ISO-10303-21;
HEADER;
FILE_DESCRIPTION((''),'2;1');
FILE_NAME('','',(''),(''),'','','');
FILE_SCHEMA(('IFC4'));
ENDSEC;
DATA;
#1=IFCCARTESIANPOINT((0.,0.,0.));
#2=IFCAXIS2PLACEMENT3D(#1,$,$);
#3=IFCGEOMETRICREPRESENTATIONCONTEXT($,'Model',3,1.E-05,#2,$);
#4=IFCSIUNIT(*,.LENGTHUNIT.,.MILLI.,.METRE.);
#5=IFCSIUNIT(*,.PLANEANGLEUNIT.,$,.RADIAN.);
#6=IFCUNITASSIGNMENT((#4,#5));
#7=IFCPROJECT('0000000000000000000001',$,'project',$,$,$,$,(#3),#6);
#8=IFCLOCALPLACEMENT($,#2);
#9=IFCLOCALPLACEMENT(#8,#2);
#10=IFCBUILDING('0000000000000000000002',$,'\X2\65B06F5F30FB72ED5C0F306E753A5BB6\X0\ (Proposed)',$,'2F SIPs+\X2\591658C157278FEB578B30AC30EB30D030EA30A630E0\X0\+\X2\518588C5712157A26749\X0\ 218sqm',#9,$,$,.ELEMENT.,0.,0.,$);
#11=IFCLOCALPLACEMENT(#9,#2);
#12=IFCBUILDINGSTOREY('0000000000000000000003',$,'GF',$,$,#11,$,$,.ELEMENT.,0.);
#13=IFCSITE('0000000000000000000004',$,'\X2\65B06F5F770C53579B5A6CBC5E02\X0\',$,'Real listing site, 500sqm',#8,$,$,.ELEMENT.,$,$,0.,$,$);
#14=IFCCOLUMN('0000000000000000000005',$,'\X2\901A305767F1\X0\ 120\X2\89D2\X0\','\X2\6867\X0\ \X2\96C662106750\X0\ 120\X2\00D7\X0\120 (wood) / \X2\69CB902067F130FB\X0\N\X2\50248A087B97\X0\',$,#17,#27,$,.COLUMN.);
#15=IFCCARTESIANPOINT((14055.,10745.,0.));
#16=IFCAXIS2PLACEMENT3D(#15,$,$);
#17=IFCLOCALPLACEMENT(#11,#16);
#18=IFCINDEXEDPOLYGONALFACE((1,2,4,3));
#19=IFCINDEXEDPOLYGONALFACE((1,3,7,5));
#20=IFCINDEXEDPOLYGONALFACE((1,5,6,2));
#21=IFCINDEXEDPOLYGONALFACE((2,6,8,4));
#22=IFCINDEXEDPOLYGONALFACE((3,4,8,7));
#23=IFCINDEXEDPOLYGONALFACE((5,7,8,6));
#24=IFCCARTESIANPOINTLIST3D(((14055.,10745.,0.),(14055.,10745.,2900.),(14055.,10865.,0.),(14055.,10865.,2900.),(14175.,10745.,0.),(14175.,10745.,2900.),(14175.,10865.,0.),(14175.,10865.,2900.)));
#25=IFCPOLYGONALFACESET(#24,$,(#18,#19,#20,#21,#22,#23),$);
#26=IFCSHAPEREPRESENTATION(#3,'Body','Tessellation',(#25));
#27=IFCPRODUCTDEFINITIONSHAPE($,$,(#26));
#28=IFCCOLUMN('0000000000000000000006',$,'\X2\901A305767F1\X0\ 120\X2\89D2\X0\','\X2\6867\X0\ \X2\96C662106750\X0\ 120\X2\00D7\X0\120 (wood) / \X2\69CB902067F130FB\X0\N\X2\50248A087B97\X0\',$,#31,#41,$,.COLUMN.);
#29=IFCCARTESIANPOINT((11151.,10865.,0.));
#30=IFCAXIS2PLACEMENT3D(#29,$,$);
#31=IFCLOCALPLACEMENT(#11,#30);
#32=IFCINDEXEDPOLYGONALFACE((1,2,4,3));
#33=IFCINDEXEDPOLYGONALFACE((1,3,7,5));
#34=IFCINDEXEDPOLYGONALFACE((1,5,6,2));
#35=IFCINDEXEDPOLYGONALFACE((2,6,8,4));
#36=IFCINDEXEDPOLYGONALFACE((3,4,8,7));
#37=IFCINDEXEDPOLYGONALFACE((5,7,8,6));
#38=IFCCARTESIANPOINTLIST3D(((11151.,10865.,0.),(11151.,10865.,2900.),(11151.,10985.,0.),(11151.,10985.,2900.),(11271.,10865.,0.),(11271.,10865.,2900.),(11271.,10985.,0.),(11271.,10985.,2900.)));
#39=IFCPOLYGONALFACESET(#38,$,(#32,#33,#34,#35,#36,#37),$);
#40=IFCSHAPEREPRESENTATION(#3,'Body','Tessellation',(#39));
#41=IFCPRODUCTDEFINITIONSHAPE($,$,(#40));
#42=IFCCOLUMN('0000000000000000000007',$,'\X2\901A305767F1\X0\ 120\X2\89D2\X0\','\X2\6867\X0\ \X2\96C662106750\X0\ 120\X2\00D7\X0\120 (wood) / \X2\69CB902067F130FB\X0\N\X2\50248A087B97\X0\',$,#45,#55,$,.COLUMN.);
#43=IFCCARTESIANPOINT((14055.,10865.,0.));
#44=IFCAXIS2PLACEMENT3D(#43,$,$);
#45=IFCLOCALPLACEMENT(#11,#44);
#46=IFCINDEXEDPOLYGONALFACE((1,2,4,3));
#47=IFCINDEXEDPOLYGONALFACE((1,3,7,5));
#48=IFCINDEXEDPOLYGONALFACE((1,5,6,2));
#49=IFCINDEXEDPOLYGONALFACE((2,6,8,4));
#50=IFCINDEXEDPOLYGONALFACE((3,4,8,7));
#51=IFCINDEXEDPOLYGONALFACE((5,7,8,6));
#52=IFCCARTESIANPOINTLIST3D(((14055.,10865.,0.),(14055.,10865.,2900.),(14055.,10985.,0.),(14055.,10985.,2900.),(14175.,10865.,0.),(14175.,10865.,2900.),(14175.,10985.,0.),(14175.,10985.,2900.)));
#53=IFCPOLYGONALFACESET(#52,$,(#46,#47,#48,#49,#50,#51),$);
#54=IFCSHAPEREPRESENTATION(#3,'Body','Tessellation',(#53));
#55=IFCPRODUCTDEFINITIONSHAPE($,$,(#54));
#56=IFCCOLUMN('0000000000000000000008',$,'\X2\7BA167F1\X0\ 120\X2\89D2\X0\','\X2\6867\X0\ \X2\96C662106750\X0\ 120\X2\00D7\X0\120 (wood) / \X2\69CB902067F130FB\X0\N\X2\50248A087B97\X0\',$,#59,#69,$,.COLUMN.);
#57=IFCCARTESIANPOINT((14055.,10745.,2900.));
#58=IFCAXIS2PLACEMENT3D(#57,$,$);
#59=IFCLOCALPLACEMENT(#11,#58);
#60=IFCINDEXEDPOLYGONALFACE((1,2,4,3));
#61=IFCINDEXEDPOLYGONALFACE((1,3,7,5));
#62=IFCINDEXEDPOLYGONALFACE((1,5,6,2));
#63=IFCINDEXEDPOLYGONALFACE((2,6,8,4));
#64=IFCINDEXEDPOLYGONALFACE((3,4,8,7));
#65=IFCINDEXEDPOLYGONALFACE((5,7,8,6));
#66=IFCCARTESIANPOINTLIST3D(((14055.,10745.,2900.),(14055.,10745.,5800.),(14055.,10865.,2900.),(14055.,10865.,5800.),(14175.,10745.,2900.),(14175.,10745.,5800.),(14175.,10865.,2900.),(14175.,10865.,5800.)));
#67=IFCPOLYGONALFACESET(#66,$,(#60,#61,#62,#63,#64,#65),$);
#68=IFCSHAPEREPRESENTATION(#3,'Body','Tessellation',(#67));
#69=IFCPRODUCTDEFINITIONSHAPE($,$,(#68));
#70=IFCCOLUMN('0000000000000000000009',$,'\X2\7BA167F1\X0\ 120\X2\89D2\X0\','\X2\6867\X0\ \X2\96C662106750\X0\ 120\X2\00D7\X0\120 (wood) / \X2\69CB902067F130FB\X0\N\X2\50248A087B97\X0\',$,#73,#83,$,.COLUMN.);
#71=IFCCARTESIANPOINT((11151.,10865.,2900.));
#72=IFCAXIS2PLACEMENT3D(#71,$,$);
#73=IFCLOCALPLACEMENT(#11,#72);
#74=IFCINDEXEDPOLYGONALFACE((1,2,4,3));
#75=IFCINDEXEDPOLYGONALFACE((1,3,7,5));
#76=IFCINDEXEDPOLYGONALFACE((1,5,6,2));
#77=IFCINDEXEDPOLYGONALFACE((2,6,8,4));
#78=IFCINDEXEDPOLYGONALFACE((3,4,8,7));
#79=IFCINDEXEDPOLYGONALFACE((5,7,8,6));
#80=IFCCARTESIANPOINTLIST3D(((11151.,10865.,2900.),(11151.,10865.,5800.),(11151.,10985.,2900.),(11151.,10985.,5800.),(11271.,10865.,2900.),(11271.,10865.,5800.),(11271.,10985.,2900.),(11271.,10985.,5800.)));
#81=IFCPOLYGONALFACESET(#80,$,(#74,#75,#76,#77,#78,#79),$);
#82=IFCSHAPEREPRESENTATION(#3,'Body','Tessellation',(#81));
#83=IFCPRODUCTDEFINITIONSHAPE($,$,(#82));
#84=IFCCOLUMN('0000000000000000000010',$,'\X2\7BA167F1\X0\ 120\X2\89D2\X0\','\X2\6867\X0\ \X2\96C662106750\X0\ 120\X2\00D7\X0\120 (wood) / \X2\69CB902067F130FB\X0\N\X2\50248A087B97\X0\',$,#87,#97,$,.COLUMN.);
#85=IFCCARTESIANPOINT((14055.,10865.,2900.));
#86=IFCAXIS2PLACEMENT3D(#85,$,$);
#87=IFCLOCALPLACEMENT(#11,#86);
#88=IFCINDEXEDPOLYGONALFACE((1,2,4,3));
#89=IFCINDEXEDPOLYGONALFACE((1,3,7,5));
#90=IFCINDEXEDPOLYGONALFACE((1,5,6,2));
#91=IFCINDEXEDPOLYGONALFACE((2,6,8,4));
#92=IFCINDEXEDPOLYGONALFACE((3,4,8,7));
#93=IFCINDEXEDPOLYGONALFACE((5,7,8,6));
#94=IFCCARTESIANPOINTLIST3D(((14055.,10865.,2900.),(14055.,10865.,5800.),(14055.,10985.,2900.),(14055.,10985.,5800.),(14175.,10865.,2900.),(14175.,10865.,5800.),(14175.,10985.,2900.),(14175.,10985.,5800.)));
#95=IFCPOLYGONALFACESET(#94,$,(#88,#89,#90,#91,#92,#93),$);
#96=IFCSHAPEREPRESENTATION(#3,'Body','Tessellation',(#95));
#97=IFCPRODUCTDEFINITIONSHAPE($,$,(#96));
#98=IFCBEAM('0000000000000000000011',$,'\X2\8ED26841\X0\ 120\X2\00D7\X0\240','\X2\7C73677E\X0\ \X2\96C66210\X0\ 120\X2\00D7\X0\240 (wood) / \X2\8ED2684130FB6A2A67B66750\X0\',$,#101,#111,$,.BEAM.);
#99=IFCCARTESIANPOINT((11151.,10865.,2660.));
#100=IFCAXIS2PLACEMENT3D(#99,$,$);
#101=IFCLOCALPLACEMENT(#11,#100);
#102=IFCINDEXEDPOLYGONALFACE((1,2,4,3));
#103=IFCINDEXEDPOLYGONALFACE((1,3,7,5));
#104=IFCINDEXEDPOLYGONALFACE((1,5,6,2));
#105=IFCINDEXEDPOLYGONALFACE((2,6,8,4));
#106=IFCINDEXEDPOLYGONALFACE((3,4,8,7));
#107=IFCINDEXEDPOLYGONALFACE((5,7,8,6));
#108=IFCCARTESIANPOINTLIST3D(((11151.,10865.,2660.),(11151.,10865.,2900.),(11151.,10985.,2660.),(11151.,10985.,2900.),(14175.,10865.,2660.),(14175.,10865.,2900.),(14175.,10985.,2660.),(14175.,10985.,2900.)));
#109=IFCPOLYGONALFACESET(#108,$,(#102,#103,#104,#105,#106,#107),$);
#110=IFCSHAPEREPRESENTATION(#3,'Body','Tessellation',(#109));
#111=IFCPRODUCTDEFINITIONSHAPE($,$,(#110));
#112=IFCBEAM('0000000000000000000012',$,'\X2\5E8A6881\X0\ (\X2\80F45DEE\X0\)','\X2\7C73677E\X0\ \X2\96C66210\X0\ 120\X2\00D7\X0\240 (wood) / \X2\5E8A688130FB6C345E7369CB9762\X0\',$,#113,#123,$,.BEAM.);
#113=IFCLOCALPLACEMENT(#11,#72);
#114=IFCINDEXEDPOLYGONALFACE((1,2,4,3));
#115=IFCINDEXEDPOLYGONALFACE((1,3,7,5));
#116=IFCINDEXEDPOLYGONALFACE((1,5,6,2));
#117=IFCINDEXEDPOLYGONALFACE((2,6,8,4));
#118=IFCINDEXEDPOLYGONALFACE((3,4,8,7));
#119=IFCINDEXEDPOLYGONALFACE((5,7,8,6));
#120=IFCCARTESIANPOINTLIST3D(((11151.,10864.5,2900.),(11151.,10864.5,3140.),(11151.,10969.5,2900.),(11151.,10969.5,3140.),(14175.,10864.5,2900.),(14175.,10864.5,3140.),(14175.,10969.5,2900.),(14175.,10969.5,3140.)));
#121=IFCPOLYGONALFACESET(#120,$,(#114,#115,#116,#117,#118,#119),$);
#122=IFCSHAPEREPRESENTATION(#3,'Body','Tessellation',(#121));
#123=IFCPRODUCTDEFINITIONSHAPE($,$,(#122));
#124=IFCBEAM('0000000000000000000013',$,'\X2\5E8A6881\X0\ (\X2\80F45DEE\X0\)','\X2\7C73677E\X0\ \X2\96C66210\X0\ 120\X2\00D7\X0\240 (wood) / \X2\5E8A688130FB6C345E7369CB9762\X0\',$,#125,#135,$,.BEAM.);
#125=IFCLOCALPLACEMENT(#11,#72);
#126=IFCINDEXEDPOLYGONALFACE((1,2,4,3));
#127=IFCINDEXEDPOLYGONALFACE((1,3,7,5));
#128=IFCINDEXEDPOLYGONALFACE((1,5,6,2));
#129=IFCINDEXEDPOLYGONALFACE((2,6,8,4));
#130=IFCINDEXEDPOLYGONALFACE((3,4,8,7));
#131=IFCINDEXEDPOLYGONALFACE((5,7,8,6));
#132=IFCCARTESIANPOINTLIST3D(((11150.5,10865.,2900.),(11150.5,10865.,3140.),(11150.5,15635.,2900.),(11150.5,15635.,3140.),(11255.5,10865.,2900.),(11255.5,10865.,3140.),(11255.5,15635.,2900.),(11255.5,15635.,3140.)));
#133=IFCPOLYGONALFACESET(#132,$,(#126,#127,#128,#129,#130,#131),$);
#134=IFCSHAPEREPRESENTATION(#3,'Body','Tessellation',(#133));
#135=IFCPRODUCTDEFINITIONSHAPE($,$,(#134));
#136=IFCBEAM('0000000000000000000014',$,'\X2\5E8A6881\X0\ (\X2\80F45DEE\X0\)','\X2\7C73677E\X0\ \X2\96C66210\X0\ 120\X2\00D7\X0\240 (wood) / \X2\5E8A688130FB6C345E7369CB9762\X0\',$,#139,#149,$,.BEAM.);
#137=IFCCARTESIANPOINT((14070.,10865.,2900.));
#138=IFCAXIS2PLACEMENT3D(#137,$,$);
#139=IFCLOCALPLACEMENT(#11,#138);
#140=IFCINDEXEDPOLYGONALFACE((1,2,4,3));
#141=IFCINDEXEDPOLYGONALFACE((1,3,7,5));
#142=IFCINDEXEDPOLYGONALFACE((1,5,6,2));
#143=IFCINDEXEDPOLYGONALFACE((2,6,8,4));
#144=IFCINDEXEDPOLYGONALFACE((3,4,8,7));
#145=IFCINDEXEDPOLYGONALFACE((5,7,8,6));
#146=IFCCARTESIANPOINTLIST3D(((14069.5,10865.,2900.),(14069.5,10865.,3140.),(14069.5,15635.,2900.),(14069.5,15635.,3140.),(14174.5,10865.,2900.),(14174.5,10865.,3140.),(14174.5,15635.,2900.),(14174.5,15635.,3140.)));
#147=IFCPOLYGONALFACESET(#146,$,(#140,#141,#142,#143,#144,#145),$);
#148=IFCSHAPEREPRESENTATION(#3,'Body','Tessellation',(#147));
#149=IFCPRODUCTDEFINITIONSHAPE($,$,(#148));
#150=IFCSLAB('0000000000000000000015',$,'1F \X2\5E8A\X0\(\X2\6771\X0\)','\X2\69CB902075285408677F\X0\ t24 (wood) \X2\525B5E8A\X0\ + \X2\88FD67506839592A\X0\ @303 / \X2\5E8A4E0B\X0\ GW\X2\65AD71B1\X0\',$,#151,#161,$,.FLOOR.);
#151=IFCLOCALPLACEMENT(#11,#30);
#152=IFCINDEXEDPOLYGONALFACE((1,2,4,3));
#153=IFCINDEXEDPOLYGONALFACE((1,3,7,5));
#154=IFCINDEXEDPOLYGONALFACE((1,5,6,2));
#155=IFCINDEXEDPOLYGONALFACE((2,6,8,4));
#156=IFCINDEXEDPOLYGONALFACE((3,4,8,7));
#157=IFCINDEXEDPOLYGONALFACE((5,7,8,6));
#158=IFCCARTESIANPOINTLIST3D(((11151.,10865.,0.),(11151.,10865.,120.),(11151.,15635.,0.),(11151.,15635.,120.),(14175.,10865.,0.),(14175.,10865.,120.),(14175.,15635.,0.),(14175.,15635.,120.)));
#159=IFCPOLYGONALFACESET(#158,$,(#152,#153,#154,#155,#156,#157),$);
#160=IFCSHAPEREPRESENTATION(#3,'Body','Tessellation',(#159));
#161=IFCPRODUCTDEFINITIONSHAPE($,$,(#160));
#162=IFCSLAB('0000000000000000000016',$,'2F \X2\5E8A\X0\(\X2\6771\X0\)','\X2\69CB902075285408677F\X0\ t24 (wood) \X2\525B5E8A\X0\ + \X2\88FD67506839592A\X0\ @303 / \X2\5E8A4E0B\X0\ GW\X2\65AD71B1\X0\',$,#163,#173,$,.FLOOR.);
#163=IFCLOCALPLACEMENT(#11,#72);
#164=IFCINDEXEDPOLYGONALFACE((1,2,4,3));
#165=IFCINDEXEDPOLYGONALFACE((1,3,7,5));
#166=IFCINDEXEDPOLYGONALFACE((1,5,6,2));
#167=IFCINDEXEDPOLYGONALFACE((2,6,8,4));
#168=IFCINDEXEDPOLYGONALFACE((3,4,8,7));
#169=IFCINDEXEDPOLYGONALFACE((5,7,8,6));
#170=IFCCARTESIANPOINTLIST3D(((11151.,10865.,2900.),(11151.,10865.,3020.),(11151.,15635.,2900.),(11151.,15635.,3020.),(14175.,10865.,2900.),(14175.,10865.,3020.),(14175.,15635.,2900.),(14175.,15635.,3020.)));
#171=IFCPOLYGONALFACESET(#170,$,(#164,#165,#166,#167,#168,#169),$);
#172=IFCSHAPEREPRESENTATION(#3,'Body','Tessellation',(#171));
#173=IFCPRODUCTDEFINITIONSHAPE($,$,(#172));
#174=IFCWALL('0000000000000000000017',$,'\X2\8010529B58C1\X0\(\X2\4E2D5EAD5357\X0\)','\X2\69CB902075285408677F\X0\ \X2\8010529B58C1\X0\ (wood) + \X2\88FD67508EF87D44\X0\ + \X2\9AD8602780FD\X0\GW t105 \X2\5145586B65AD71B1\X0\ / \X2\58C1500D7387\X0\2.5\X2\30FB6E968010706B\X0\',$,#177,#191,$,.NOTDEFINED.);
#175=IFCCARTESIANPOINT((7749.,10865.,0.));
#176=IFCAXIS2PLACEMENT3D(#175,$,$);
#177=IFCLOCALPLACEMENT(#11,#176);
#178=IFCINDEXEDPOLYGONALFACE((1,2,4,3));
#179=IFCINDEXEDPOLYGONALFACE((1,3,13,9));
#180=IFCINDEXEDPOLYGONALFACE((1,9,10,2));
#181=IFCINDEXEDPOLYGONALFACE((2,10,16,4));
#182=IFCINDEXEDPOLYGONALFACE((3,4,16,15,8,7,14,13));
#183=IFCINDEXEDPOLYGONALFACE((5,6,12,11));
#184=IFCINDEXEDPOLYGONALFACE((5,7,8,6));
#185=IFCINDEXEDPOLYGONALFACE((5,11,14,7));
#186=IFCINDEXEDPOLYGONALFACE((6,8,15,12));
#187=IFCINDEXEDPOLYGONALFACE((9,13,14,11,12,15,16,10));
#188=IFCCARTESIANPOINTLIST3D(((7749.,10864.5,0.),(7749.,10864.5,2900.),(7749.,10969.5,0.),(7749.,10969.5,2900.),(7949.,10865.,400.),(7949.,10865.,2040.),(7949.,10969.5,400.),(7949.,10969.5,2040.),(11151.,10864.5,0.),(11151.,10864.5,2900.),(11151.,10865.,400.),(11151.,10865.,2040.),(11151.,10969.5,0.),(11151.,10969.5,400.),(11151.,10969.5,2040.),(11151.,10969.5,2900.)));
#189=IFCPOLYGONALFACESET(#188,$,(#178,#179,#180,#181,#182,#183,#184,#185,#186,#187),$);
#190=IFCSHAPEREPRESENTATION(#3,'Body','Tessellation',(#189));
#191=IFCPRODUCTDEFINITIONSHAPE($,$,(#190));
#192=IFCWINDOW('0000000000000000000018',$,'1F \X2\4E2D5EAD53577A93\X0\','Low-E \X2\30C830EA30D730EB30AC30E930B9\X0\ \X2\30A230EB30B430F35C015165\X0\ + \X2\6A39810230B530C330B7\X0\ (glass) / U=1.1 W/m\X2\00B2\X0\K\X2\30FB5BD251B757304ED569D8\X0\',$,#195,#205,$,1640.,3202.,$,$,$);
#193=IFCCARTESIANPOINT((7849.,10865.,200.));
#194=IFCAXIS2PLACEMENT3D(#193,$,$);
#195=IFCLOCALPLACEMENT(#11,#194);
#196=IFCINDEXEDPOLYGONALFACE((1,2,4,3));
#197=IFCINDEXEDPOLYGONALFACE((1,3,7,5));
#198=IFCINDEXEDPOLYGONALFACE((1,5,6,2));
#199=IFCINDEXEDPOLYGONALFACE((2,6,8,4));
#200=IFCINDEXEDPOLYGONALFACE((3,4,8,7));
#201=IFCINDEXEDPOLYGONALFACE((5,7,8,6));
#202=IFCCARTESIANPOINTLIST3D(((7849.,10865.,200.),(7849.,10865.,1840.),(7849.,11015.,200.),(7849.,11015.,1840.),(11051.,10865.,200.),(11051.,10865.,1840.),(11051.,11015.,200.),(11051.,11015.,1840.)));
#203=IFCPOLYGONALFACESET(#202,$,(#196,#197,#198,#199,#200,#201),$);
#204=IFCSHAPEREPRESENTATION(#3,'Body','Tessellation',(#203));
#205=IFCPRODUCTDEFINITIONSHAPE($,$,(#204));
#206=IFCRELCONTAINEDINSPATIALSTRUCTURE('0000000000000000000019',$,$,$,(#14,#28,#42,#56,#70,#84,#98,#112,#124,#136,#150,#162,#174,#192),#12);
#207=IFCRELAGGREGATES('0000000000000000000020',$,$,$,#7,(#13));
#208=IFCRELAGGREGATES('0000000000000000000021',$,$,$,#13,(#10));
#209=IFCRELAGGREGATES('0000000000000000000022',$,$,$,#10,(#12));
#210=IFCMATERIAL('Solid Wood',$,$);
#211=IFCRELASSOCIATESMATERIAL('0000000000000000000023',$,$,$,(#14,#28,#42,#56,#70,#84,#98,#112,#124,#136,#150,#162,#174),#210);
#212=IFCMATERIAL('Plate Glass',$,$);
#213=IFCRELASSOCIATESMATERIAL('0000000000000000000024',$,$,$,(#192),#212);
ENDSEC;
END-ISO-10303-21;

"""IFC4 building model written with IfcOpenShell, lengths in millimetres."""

from ifc_helpers import new_model, si_unit, frame, frame_2d, origin, place, context, project, spatial, rectangle, extrude, material, element, fill, save


model = new_model("IFC4")

# Units and contexts
model_context = context("Model", 3, precision=1e-05, world=origin())
ifc_project = project(units=[si_unit("LENGTHUNIT", "METRE", prefix="MILLI"), si_unit("PLANEANGLEUNIT", "RADIAN")], contexts=[model_context])

# Site, building, storey
site_placement = place(None, origin())
site = spatial("IfcSite", under=ifc_project, at=site_placement, Name="新潟県南魚沼市", ObjectType="Real listing site, 500sqm", CompositionType="ELEMENT", RefElevation=0.0)
building_placement = place(site_placement, origin())
building = spatial("IfcBuilding", under=site, at=building_placement, Name="新潟・狭小の町家 (Proposed)", ObjectType="2F SIPs+外壁圧迫型ガルバリウム+内装無垢杉 218sqm", CompositionType="ELEMENT", ElevationOfRefHeight=0.0, ElevationOfTerrain=0.0)
storey_placement = place(building_placement, origin())
storey = spatial("IfcBuildingStorey", under=building, at=storey_placement, Name="GF", CompositionType="ELEMENT", Elevation=0.0)

# Columns
ifc_material_1 = material(Name="Solid Wood")
column_1_placement = place(storey_placement, frame((14055.0, 10745.0, 0.0)))
element("IfcColumn", 1, at=column_1_placement, inside=storey, material=ifc_material_1, Name="通し柱 120角", Description="桧 集成材 120×120 (wood) / 構造柱・N値計算", PredefinedType="COLUMN", context=model_context, shape_type="SweptSolid", body=[
    extrude(rectangle(XDim=120.0, YDim=120.0, at=frame_2d((60.0, 60.0))), frame((14055.0, 10745.0, 0.0)), (0.0, 0.0, 1.0), 2900.0),
])
column_2_placement = place(storey_placement, frame((11151.0, 10865.0, 0.0)))
element("IfcColumn", 2, at=column_2_placement, inside=storey, material=ifc_material_1, Name="通し柱 120角", Description="桧 集成材 120×120 (wood) / 構造柱・N値計算", PredefinedType="COLUMN", context=model_context, shape_type="SweptSolid", body=[
    extrude(rectangle(XDim=120.0, YDim=120.0, at=frame_2d((60.0, 60.0))), frame((11151.0, 10865.0, 0.0)), (0.0, 0.0, 1.0), 2900.0),
])
column_3_placement = place(storey_placement, frame((14055.0, 10865.0, 0.0)))
element("IfcColumn", 3, at=column_3_placement, inside=storey, material=ifc_material_1, Name="通し柱 120角", Description="桧 集成材 120×120 (wood) / 構造柱・N値計算", PredefinedType="COLUMN", context=model_context, shape_type="SweptSolid", body=[
    extrude(rectangle(XDim=120.0, YDim=120.0, at=frame_2d((60.0, 60.0))), frame((14055.0, 10865.0, 0.0)), (0.0, 0.0, 1.0), 2900.0),
])
column_4_placement = place(storey_placement, frame((14055.0, 10745.0, 2900.0)))
element("IfcColumn", 4, at=column_4_placement, inside=storey, material=ifc_material_1, Name="管柱 120角", Description="桧 集成材 120×120 (wood) / 構造柱・N値計算", PredefinedType="COLUMN", context=model_context, shape_type="SweptSolid", body=[
    extrude(rectangle(XDim=120.0, YDim=120.0, at=frame_2d((60.0, 60.0))), frame((14055.0, 10745.0, 2900.0)), (0.0, 0.0, 1.0), 2900.0),
])
column_5_placement = place(storey_placement, frame((11151.0, 10865.0, 2900.0)))
element("IfcColumn", 5, at=column_5_placement, inside=storey, material=ifc_material_1, Name="管柱 120角", Description="桧 集成材 120×120 (wood) / 構造柱・N値計算", PredefinedType="COLUMN", context=model_context, shape_type="SweptSolid", body=[
    extrude(rectangle(XDim=120.0, YDim=120.0, at=frame_2d((60.0, 60.0))), frame((11151.0, 10865.0, 2900.0)), (0.0, 0.0, 1.0), 2900.0),
])
column_6_placement = place(storey_placement, frame((14055.0, 10865.0, 2900.0)))
element("IfcColumn", 6, at=column_6_placement, inside=storey, material=ifc_material_1, Name="管柱 120角", Description="桧 集成材 120×120 (wood) / 構造柱・N値計算", PredefinedType="COLUMN", context=model_context, shape_type="SweptSolid", body=[
    extrude(rectangle(XDim=120.0, YDim=120.0, at=frame_2d((60.0, 60.0))), frame((14055.0, 10865.0, 2900.0)), (0.0, 0.0, 1.0), 2900.0),
])

# Beams
beam_1_placement = place(storey_placement, frame((11151.0, 10865.0, 2660.0)))
element("IfcBeam", 7, at=beam_1_placement, inside=storey, material=ifc_material_1, Name="軒桁 120×240", Description="米松 集成 120×240 (wood) / 軒桁・横架材", PredefinedType="BEAM", context=model_context, shape_type="SweptSolid", body=[
    extrude(rectangle(XDim=3024.0, YDim=120.0, at=frame_2d((1512.0, 60.0))), frame((11151.0, 10865.0, 2660.0)), (0.0, 0.0, 1.0), 240.0),
])
beam_2_placement = place(storey_placement, frame((11151.0, 10865.0, 2900.0)))
element("IfcBeam", 8, at=beam_2_placement, inside=storey, material=ifc_material_1, Name="床梁 (胴差)", Description="米松 集成 120×240 (wood) / 床梁・水平構面", PredefinedType="BEAM", context=model_context, shape_type="SweptSolid", body=[
    extrude(rectangle(XDim=3024.0, YDim=105.0, at=frame_2d((1512.0, 52.0))), frame((11151.0, 10865.0, 2900.0)), (0.0, 0.0, 1.0), 240.0),
])
beam_3_placement = place(storey_placement, frame((11151.0, 10865.0, 2900.0)))
element("IfcBeam", 9, at=beam_3_placement, inside=storey, material=ifc_material_1, Name="床梁 (胴差)", Description="米松 集成 120×240 (wood) / 床梁・水平構面", PredefinedType="BEAM", context=model_context, shape_type="SweptSolid", body=[
    extrude(rectangle(XDim=105.0, YDim=4770.0, at=frame_2d((52.0, 2385.0))), frame((11151.0, 10865.0, 2900.0)), (0.0, 0.0, 1.0), 240.0),
])
beam_4_placement = place(storey_placement, frame((14070.0, 10865.0, 2900.0)))
element("IfcBeam", 10, at=beam_4_placement, inside=storey, material=ifc_material_1, Name="床梁 (胴差)", Description="米松 集成 120×240 (wood) / 床梁・水平構面", PredefinedType="BEAM", context=model_context, shape_type="SweptSolid", body=[
    extrude(rectangle(XDim=105.0, YDim=4770.0, at=frame_2d((52.0, 2385.0))), frame((14070.0, 10865.0, 2900.0)), (0.0, 0.0, 1.0), 240.0),
])

# Slabs
slab_1_placement = place(storey_placement, frame((11151.0, 10865.0, 0.0)))
element("IfcSlab", 11, at=slab_1_placement, inside=storey, material=ifc_material_1, Name="1F 床(東)", Description="構造用合板 t24 (wood) 剛床 + 製材根太 @303 / 床下 GW断熱", PredefinedType="FLOOR", context=model_context, shape_type="SweptSolid", body=[
    extrude(rectangle(XDim=3024.0, YDim=4770.0, at=frame_2d((1512.0, 2385.0))), frame((11151.0, 10865.0, 0.0)), (0.0, 0.0, 1.0), 120.0),
])
slab_2_placement = place(storey_placement, frame((11151.0, 10865.0, 2900.0)))
element("IfcSlab", 12, at=slab_2_placement, inside=storey, material=ifc_material_1, Name="2F 床(東)", Description="構造用合板 t24 (wood) 剛床 + 製材根太 @303 / 床下 GW断熱", PredefinedType="FLOOR", context=model_context, shape_type="SweptSolid", body=[
    extrude(rectangle(XDim=3024.0, YDim=4770.0, at=frame_2d((1512.0, 2385.0))), frame((11151.0, 10865.0, 2900.0)), (0.0, 0.0, 1.0), 120.0),
])

# Wall, opening, window
wall_1_placement = place(storey_placement, frame((7749.0, 10865.0, 0.0)))
wall_1 = element("IfcWall", 13, at=wall_1_placement, inside=storey, material=ifc_material_1, Name="耐力壁(中庭南)", Description="構造用合板 耐力壁 (wood) + 製材軸組 + 高性能GW t105 充填断熱 / 壁倍率2.5・準耐火", PredefinedType="NOTDEFINED", context=model_context, shape_type="SweptSolid", body=[
    extrude(rectangle(XDim=3402.0, YDim=105.0, at=frame_2d((1701.0, 52.0))), frame((7749.0, 10865.0, 0.0)), (0.0, 0.0, 1.0), 2900.0),
])
opening_1_placement = place(storey_placement, frame((7849.0, 10865.0, 200.0)))
opening_1 = element("IfcOpeningElement", 14, at=opening_1_placement, cuts=wall_1, PredefinedType="NOTDEFINED", context=model_context, shape_type="SweptSolid", body=[
    extrude(rectangle(XDim=3202.0, YDim=150.0, at=frame_2d((1601.0, 75.0))), frame((7849.0, 10865.0, 200.0)), (0.0, 0.0, 1.0), 1640.0),
])
ifc_material_2 = material(Name="Plate Glass")
window_1_placement = place(storey_placement, frame((7849.0, 10865.0, 200.0)))
window_1 = element("IfcWindow", 15, at=window_1_placement, inside=storey, material=ifc_material_2, Name="1F 中庭南窓", Description="Low-E トリプルガラス アルゴン封入 + 樹脂サッシ (glass) / U=1.1 W/m²K・寒冷地仕様", OverallHeight=1640.0, OverallWidth=3202.0, context=model_context, shape_type="SweptSolid", body=[
    extrude(rectangle(XDim=3202.0, YDim=150.0, at=frame_2d((1601.0, 75.0))), frame((7849.0, 10865.0, 200.0)), (0.0, 0.0, 1.0), 1640.0),
])
fill(opening_1, window_1)

save(model, "model.ifc")
